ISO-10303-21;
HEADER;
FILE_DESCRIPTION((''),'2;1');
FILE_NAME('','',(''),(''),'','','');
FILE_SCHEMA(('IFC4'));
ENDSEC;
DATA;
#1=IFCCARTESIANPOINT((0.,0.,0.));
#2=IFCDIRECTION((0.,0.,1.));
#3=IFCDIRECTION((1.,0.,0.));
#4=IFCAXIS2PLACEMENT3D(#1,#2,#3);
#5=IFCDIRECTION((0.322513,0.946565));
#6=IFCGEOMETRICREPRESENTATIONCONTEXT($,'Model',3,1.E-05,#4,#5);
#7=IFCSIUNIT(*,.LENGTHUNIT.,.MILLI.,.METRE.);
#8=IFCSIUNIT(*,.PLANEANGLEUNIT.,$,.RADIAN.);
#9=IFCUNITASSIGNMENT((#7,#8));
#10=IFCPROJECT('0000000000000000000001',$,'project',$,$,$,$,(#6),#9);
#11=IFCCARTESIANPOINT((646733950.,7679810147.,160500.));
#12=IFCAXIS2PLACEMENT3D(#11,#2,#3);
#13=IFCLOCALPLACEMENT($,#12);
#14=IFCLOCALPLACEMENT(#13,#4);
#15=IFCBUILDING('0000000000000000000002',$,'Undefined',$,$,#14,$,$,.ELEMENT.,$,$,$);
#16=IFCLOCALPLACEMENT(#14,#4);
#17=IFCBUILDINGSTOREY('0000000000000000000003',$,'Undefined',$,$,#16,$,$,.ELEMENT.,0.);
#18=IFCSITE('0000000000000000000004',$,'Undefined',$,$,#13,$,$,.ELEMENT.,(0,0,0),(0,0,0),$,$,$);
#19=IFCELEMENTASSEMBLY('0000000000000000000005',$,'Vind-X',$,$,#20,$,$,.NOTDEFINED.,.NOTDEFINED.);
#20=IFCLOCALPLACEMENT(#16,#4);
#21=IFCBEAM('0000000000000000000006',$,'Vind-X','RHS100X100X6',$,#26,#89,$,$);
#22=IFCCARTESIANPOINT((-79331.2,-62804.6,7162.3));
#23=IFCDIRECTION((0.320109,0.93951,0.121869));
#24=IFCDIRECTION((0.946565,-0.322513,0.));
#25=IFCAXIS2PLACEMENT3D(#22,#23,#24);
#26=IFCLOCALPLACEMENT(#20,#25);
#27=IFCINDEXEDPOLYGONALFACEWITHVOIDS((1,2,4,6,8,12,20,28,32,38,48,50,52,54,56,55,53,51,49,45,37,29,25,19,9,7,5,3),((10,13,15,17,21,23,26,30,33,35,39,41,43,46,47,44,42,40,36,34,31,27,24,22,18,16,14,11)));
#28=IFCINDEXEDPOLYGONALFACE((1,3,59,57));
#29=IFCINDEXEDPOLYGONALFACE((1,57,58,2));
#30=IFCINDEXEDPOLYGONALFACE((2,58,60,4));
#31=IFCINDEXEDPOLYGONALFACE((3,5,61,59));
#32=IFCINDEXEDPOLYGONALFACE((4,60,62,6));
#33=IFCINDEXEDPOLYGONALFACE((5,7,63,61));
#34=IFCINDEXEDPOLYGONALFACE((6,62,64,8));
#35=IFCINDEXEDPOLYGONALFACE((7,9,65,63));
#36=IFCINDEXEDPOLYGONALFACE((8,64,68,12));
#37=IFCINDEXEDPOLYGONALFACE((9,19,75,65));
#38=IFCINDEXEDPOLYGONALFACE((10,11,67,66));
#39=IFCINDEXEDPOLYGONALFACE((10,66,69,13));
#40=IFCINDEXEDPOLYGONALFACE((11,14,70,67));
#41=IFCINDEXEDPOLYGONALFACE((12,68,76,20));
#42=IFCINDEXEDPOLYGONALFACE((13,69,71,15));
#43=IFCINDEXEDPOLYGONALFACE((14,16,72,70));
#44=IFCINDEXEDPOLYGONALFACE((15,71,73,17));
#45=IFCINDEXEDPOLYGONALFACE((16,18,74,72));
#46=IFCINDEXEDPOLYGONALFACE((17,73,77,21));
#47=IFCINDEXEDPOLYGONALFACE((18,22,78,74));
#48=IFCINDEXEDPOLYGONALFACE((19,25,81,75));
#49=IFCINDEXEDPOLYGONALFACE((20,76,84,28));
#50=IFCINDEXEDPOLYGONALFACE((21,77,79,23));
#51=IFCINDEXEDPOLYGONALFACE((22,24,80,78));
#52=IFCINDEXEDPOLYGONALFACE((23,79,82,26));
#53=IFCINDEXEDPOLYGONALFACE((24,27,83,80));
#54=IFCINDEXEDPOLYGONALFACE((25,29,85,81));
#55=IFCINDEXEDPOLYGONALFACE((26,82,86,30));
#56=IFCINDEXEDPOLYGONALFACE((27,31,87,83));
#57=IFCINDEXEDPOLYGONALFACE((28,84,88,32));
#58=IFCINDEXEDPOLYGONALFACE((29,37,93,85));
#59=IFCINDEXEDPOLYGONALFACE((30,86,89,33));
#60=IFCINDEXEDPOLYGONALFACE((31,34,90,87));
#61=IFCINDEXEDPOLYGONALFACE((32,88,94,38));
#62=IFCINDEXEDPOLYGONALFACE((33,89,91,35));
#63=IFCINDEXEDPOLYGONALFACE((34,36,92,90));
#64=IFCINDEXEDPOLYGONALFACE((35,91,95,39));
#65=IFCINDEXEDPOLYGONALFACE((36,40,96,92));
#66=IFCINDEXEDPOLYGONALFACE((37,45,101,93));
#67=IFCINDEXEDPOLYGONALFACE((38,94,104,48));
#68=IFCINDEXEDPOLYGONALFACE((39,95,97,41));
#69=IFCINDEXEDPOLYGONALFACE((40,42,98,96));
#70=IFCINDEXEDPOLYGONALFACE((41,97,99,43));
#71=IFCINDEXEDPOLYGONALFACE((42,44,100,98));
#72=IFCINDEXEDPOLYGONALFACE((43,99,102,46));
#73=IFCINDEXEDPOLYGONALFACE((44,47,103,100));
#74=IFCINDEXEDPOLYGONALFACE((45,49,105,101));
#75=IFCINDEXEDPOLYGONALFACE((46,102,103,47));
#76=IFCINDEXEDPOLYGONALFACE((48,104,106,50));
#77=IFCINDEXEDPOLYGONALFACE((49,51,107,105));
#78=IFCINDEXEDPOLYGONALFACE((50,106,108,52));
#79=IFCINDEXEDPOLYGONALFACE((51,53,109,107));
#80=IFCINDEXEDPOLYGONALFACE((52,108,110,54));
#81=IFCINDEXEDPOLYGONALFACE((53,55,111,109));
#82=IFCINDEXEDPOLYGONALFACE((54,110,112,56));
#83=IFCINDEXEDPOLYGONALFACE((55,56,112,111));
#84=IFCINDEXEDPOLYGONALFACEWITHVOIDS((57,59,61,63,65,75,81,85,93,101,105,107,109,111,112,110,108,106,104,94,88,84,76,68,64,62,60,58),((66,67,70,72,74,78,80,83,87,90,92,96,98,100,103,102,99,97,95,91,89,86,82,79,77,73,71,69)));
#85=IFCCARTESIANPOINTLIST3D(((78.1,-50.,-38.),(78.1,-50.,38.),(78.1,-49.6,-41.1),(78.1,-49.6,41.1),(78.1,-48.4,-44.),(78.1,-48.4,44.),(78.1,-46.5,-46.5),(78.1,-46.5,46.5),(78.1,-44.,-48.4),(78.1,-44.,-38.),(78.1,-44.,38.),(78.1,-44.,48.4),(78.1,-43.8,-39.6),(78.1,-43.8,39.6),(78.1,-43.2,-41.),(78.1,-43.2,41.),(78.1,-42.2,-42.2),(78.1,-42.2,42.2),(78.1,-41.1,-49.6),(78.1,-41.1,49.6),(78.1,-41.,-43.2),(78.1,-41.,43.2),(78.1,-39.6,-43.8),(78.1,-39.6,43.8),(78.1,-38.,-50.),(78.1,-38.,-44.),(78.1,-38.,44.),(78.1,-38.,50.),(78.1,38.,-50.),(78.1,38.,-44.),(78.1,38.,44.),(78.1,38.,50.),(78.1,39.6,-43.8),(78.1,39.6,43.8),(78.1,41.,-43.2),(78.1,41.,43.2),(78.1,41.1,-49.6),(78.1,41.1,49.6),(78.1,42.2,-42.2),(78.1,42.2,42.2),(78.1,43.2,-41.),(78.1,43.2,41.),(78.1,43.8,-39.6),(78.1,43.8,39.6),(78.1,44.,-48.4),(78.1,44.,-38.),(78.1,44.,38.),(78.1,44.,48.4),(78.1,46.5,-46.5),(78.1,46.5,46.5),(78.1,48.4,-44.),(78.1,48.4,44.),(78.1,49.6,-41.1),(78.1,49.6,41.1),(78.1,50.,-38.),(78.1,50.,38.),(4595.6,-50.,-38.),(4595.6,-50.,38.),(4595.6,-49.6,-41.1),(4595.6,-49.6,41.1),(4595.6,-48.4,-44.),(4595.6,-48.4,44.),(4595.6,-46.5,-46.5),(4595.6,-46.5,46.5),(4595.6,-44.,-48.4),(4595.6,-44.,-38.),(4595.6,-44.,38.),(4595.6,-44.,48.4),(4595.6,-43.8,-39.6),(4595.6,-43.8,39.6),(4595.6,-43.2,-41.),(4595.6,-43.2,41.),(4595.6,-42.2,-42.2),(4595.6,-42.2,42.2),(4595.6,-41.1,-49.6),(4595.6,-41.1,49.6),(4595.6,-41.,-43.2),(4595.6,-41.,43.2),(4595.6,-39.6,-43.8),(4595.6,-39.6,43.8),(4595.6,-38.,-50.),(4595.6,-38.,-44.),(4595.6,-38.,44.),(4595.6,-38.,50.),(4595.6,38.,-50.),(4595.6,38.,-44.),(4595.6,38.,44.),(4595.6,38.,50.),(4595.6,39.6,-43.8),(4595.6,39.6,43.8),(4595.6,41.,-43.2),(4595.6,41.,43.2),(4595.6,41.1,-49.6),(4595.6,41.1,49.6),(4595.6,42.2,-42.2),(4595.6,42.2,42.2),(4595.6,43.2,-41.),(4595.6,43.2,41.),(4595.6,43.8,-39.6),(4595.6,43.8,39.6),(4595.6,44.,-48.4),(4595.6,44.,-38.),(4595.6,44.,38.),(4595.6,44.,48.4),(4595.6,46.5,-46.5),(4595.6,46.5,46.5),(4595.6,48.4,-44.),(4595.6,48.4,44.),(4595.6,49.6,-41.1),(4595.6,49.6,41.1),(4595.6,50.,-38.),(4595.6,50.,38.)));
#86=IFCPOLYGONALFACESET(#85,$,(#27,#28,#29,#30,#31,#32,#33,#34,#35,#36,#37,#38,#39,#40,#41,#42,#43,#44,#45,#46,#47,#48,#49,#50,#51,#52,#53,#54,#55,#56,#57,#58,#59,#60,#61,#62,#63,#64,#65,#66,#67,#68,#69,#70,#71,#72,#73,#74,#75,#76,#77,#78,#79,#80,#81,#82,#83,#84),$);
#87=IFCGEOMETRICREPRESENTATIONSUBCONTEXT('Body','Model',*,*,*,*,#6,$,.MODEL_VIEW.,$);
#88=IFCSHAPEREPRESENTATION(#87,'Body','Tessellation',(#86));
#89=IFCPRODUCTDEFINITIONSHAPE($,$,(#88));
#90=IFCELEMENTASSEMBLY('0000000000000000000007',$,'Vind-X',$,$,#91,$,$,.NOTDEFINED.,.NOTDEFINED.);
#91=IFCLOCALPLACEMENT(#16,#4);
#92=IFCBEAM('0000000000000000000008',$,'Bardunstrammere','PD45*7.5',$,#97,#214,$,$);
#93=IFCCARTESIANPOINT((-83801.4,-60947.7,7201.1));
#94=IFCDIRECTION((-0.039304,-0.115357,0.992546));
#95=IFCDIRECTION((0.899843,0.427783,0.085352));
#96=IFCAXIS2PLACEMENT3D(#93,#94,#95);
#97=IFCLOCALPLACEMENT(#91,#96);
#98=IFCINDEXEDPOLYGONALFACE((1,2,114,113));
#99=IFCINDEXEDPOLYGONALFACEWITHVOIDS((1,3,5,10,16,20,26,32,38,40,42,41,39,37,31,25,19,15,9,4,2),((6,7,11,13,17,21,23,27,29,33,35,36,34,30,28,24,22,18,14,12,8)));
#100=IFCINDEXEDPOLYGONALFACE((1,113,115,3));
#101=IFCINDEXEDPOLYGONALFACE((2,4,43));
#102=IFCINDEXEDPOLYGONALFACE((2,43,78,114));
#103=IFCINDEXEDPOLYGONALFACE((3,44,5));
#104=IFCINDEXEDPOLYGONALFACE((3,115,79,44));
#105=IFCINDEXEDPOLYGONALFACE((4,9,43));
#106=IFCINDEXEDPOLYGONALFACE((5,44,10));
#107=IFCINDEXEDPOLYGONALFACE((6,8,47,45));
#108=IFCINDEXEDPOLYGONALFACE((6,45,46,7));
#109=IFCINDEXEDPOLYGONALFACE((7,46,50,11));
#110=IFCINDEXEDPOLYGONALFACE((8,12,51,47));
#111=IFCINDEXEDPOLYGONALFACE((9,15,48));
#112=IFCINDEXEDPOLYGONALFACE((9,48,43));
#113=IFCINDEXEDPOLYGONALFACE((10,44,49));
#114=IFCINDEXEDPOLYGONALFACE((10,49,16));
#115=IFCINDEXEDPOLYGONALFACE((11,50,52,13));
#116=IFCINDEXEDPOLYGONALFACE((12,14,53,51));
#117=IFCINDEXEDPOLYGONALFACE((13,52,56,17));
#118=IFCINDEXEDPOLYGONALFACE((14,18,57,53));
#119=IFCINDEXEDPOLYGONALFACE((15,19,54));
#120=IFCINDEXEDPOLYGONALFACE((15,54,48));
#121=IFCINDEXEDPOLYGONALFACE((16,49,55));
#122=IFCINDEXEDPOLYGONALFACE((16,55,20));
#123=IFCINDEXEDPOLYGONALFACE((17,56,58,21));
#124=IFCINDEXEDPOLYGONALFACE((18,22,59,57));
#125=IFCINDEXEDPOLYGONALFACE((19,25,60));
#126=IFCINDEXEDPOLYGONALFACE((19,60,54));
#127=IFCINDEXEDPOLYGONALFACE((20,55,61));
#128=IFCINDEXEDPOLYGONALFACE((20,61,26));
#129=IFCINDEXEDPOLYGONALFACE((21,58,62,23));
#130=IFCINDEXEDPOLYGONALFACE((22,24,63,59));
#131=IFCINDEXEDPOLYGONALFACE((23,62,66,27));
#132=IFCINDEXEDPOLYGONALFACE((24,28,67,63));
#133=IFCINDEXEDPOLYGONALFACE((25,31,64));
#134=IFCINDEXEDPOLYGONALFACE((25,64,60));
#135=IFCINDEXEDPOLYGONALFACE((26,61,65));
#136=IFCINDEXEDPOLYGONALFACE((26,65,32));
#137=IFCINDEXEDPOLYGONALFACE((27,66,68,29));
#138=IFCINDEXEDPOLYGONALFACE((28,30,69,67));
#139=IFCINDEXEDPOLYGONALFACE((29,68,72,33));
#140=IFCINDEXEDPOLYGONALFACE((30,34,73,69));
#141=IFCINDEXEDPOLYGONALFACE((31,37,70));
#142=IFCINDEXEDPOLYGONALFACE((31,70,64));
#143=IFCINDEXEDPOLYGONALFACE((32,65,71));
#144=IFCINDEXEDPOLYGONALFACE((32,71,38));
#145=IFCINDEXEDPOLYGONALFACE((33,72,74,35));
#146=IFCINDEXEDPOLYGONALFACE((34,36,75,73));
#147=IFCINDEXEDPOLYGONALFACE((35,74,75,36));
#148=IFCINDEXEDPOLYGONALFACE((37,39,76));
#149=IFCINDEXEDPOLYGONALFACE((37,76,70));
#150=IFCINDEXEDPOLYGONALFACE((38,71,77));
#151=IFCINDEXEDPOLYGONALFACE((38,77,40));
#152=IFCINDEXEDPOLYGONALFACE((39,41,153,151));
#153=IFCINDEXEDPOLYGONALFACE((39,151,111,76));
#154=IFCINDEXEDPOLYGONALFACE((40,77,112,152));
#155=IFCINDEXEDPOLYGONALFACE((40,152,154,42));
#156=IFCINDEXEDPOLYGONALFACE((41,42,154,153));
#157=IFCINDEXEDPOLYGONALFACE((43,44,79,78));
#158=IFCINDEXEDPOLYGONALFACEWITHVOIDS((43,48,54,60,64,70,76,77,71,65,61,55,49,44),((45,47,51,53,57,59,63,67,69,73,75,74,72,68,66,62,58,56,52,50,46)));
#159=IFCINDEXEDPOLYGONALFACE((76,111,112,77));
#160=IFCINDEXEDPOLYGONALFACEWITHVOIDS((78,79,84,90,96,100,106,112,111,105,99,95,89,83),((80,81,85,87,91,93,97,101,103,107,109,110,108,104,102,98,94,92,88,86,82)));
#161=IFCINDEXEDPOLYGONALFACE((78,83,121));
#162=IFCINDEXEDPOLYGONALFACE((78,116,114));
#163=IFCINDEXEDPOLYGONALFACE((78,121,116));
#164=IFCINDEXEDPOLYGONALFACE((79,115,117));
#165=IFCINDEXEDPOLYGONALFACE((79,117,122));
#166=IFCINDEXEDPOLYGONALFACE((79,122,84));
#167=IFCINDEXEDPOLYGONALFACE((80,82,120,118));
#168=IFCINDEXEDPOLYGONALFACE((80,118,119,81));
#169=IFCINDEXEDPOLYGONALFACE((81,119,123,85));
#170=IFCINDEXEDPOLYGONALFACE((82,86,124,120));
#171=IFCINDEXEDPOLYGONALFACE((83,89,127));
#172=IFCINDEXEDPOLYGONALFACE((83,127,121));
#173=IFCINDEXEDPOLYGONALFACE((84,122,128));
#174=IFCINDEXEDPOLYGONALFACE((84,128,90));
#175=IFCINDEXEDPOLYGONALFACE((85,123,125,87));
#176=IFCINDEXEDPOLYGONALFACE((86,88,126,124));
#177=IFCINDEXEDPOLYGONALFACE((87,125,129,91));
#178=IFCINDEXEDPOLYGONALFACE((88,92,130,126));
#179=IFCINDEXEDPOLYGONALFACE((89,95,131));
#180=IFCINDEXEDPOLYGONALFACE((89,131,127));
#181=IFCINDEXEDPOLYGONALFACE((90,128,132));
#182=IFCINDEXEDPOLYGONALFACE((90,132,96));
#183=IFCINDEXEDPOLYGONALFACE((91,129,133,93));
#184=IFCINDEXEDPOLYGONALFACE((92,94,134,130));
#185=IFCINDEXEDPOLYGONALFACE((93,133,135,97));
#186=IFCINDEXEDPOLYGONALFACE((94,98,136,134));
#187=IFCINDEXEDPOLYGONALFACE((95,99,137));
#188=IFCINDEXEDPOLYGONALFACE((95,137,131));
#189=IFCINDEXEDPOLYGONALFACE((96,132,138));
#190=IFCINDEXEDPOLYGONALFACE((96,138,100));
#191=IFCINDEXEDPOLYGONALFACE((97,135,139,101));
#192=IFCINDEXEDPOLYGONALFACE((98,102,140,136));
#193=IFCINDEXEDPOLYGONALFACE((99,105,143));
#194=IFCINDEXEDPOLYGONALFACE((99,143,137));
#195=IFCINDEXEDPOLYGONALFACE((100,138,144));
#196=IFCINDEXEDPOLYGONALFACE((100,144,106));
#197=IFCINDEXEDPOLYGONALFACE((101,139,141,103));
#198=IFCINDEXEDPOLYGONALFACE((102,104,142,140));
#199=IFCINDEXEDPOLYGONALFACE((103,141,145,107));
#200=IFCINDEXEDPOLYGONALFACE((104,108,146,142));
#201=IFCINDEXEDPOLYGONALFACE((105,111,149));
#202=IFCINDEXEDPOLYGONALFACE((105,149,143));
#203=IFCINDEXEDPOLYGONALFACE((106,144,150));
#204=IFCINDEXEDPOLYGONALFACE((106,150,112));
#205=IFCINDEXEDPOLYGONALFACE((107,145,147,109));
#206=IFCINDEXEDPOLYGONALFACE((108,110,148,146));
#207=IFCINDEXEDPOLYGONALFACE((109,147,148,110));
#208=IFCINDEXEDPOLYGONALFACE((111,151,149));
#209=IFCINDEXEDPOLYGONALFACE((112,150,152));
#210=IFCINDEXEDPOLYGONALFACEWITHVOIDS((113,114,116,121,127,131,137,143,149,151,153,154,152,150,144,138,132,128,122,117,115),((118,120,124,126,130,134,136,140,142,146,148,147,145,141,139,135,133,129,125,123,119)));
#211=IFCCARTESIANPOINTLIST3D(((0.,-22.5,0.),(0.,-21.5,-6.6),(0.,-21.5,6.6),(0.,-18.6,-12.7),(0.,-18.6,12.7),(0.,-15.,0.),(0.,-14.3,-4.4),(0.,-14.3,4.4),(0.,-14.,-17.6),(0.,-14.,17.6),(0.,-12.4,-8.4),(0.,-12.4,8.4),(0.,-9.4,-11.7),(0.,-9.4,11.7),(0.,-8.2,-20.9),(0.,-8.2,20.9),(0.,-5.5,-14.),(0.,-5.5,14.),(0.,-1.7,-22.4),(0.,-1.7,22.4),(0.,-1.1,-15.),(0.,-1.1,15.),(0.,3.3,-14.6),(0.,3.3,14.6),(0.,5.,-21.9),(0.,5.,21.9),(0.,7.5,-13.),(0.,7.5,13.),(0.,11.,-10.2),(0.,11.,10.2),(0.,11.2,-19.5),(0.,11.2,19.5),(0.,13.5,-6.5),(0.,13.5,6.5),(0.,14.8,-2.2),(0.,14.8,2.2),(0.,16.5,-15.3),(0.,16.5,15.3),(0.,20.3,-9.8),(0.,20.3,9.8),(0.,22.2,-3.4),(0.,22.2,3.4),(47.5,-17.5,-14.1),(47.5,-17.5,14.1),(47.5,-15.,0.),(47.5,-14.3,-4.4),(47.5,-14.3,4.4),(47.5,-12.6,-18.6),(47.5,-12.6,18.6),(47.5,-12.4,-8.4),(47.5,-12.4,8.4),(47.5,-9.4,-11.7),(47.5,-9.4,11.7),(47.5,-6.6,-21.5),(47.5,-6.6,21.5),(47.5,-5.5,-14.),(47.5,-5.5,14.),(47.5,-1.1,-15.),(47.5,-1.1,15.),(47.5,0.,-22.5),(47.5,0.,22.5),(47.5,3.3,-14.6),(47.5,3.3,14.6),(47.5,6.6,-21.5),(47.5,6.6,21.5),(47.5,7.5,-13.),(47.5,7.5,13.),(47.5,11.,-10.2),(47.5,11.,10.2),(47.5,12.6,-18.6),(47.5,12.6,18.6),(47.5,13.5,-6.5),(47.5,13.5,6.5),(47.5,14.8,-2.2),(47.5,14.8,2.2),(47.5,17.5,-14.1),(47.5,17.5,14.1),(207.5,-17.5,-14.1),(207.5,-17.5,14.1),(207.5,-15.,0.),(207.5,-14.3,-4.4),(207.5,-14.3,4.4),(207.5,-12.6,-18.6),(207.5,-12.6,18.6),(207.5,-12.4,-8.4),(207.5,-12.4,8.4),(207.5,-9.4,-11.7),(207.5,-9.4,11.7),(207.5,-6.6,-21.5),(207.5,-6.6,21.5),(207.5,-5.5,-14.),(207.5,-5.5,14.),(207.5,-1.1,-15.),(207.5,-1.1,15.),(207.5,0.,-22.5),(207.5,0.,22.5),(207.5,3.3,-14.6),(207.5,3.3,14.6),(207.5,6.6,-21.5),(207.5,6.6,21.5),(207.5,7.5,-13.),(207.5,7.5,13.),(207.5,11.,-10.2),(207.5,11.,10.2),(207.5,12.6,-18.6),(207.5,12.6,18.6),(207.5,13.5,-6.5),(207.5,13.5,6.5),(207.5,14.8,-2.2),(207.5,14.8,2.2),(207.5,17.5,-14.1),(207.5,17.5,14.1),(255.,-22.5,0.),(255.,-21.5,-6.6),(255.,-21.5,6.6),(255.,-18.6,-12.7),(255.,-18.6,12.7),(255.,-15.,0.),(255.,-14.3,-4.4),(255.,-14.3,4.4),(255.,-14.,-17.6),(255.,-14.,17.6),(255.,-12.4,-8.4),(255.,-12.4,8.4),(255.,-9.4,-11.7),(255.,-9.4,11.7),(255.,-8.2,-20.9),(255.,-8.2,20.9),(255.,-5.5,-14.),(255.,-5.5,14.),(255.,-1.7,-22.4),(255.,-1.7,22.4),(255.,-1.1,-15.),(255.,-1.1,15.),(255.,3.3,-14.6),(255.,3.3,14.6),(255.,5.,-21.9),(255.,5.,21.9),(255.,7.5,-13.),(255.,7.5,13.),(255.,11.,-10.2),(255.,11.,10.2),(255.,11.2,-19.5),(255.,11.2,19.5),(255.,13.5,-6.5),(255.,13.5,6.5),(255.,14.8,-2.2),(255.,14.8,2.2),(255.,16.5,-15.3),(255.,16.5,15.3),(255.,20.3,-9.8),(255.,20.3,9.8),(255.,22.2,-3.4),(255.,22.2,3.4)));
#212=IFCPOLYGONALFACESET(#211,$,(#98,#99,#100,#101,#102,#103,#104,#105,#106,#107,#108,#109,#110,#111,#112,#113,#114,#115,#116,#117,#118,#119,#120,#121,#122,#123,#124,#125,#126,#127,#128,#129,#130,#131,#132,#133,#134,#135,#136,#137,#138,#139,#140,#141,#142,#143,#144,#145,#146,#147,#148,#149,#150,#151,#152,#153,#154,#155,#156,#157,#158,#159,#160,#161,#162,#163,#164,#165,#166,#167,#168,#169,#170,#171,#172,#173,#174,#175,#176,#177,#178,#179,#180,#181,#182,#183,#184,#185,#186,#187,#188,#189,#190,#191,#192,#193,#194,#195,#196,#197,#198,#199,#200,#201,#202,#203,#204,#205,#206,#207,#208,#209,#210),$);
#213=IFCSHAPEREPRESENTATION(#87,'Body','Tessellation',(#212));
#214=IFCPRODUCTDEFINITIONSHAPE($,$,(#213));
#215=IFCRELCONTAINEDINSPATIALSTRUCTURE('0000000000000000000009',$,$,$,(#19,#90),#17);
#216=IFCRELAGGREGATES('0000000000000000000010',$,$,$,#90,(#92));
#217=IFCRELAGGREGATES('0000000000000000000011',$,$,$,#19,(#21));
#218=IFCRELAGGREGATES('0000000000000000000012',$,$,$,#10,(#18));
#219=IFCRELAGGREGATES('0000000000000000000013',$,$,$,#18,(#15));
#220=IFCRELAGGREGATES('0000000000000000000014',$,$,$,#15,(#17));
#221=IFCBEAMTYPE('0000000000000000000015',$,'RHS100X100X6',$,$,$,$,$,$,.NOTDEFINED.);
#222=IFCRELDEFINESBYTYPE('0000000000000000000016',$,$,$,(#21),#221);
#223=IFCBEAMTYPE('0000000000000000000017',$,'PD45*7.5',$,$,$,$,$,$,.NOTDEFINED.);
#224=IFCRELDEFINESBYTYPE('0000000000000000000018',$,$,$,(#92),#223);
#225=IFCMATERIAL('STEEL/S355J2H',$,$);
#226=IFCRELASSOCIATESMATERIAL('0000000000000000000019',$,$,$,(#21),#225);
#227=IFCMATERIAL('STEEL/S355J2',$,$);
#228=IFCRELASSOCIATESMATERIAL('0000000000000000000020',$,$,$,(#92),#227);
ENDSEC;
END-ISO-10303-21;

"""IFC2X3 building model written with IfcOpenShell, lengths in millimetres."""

from ifc_helpers import new_model, si_unit, direction, frame, origin_with_axes, origin_2d_with_axis, place, context, subcontext, project, spatial, rectangle, hollow_rectangle, hollow_circle, extrude, boolean, clip, halfspace, material, type_object, element, aggregate, save


model = new_model("IFC2X3")

# Units and contexts
model_context = context("Model", 3, precision=1e-05, world=origin_with_axes(), true_north=direction((0.322513, 0.946565)))
body_context = subcontext(model_context, "Body", "Model", "MODEL_VIEW")
ifc_project = project(units=[si_unit("LENGTHUNIT", "METRE", prefix="MILLI"), si_unit("PLANEANGLEUNIT", "RADIAN")], contexts=[model_context])

# Site, building, storey
site_placement = place(None, frame((646733950.0, 7679810147.0, 160500.0), z_axis=(0.0, 0.0, 1.0), x_axis=(1.0, 0.0, 0.0)))
site = spatial("IfcSite", under=ifc_project, at=site_placement, Name="Undefined", CompositionType="ELEMENT", RefLatitude=(0, 0, 0), RefLongitude=(0, 0, 0))
building_placement = place(site_placement, origin_with_axes())
building = spatial("IfcBuilding", under=site, at=building_placement, Name="Undefined", CompositionType="ELEMENT")
storey_placement = place(building_placement, origin_with_axes())
storey = spatial("IfcBuildingStorey", under=building, at=storey_placement, Name="Undefined", CompositionType="ELEMENT", Elevation=0.0)

# Element assemblies, beams
assembly_1_placement = place(storey_placement, origin_with_axes())
assembly_1 = element("IfcElementAssembly", 1, at=assembly_1_placement, inside=storey, Name="Vind-X", AssemblyPlace="NOTDEFINED", PredefinedType="NOTDEFINED")
ifc_material_1 = material(Name="STEEL/S355J2H")
beam_type_1 = type_object("IfcBeamType", Name="RHS100X100X6", PredefinedType="NOTDEFINED")
beam_1_placement = place(assembly_1_placement, frame((-79331.2, -62804.6, 7162.3), z_axis=(0.320109, 0.93951, 0.121869), x_axis=(0.946565, -0.322513, 0.0)))
beam_1 = element("IfcBeam", 2, at=beam_1_placement, type_object=beam_type_1, material=ifc_material_1, Name="Vind-X", Description="RHS100X100X6", context=body_context, shape_type="Clipping", body=[
    clip(clip(extrude(hollow_rectangle(XDim=100.0, YDim=100.0, WallThickness=6.0, InnerFilletRadius=6.0, OuterFilletRadius=12.0, at=origin_2d_with_axis()), frame((4674.6, 0.0, 0.0), z_axis=(-1.0, 0.0, 0.0), x_axis=(0.0, -1.0, 0.0)), (0.0, 0.0, 1.0), 4674.6), halfspace(frame((4595.6, 22.5, 0.0), z_axis=(-1.0, 0.0, 0.0), x_axis=(0.0, 0.0, 1.0)), True)), halfspace(frame((78.1, 22.5, 0.0), z_axis=(1.0, 0.0, 0.0), x_axis=(0.0, 0.0, -1.0)), True)),
])
assembly_2_placement = place(storey_placement, origin_with_axes())
assembly_2 = element("IfcElementAssembly", 3, at=assembly_2_placement, inside=storey, Name="Vind-X", AssemblyPlace="NOTDEFINED", PredefinedType="NOTDEFINED")
ifc_material_2 = material(Name="STEEL/S355J2")
beam_type_2 = type_object("IfcBeamType", Name="PD45*7.5", PredefinedType="NOTDEFINED")
beam_2_placement = place(assembly_2_placement, frame((-83801.4, -60947.7, 7201.1), z_axis=(-0.039304, -0.115357, 0.992546), x_axis=(0.899843, 0.427783, 0.085352)))
beam_2 = element("IfcBeam", 4, at=beam_2_placement, type_object=beam_type_2, material=ifc_material_2, Name="Bardunstrammere", Description="PD45*7.5", context=body_context, shape_type="CSG", body=[
    boolean("DIFFERENCE", extrude(hollow_circle(Radius=22.5, WallThickness=7.5, at=origin_2d_with_axis()), frame((255.0, 0.0, 0.0), z_axis=(-1.0, 0.0, 0.0), x_axis=(0.0, -1.0, 0.0)), (0.0, 0.0, 1.0), 255.0), extrude(rectangle(XDim=35.0, YDim=90.0, at=origin_2d_with_axis()), frame((207.5, 0.0, 0.0), z_axis=(-1.0, 0.0, 0.0), x_axis=(0.0, -1.0, 0.0)), (0.0, 0.0, 1.0), 160.0)),
])

aggregate(assembly_2, [beam_2])

aggregate(assembly_1, [beam_1])

save(model, "model.ifc")
